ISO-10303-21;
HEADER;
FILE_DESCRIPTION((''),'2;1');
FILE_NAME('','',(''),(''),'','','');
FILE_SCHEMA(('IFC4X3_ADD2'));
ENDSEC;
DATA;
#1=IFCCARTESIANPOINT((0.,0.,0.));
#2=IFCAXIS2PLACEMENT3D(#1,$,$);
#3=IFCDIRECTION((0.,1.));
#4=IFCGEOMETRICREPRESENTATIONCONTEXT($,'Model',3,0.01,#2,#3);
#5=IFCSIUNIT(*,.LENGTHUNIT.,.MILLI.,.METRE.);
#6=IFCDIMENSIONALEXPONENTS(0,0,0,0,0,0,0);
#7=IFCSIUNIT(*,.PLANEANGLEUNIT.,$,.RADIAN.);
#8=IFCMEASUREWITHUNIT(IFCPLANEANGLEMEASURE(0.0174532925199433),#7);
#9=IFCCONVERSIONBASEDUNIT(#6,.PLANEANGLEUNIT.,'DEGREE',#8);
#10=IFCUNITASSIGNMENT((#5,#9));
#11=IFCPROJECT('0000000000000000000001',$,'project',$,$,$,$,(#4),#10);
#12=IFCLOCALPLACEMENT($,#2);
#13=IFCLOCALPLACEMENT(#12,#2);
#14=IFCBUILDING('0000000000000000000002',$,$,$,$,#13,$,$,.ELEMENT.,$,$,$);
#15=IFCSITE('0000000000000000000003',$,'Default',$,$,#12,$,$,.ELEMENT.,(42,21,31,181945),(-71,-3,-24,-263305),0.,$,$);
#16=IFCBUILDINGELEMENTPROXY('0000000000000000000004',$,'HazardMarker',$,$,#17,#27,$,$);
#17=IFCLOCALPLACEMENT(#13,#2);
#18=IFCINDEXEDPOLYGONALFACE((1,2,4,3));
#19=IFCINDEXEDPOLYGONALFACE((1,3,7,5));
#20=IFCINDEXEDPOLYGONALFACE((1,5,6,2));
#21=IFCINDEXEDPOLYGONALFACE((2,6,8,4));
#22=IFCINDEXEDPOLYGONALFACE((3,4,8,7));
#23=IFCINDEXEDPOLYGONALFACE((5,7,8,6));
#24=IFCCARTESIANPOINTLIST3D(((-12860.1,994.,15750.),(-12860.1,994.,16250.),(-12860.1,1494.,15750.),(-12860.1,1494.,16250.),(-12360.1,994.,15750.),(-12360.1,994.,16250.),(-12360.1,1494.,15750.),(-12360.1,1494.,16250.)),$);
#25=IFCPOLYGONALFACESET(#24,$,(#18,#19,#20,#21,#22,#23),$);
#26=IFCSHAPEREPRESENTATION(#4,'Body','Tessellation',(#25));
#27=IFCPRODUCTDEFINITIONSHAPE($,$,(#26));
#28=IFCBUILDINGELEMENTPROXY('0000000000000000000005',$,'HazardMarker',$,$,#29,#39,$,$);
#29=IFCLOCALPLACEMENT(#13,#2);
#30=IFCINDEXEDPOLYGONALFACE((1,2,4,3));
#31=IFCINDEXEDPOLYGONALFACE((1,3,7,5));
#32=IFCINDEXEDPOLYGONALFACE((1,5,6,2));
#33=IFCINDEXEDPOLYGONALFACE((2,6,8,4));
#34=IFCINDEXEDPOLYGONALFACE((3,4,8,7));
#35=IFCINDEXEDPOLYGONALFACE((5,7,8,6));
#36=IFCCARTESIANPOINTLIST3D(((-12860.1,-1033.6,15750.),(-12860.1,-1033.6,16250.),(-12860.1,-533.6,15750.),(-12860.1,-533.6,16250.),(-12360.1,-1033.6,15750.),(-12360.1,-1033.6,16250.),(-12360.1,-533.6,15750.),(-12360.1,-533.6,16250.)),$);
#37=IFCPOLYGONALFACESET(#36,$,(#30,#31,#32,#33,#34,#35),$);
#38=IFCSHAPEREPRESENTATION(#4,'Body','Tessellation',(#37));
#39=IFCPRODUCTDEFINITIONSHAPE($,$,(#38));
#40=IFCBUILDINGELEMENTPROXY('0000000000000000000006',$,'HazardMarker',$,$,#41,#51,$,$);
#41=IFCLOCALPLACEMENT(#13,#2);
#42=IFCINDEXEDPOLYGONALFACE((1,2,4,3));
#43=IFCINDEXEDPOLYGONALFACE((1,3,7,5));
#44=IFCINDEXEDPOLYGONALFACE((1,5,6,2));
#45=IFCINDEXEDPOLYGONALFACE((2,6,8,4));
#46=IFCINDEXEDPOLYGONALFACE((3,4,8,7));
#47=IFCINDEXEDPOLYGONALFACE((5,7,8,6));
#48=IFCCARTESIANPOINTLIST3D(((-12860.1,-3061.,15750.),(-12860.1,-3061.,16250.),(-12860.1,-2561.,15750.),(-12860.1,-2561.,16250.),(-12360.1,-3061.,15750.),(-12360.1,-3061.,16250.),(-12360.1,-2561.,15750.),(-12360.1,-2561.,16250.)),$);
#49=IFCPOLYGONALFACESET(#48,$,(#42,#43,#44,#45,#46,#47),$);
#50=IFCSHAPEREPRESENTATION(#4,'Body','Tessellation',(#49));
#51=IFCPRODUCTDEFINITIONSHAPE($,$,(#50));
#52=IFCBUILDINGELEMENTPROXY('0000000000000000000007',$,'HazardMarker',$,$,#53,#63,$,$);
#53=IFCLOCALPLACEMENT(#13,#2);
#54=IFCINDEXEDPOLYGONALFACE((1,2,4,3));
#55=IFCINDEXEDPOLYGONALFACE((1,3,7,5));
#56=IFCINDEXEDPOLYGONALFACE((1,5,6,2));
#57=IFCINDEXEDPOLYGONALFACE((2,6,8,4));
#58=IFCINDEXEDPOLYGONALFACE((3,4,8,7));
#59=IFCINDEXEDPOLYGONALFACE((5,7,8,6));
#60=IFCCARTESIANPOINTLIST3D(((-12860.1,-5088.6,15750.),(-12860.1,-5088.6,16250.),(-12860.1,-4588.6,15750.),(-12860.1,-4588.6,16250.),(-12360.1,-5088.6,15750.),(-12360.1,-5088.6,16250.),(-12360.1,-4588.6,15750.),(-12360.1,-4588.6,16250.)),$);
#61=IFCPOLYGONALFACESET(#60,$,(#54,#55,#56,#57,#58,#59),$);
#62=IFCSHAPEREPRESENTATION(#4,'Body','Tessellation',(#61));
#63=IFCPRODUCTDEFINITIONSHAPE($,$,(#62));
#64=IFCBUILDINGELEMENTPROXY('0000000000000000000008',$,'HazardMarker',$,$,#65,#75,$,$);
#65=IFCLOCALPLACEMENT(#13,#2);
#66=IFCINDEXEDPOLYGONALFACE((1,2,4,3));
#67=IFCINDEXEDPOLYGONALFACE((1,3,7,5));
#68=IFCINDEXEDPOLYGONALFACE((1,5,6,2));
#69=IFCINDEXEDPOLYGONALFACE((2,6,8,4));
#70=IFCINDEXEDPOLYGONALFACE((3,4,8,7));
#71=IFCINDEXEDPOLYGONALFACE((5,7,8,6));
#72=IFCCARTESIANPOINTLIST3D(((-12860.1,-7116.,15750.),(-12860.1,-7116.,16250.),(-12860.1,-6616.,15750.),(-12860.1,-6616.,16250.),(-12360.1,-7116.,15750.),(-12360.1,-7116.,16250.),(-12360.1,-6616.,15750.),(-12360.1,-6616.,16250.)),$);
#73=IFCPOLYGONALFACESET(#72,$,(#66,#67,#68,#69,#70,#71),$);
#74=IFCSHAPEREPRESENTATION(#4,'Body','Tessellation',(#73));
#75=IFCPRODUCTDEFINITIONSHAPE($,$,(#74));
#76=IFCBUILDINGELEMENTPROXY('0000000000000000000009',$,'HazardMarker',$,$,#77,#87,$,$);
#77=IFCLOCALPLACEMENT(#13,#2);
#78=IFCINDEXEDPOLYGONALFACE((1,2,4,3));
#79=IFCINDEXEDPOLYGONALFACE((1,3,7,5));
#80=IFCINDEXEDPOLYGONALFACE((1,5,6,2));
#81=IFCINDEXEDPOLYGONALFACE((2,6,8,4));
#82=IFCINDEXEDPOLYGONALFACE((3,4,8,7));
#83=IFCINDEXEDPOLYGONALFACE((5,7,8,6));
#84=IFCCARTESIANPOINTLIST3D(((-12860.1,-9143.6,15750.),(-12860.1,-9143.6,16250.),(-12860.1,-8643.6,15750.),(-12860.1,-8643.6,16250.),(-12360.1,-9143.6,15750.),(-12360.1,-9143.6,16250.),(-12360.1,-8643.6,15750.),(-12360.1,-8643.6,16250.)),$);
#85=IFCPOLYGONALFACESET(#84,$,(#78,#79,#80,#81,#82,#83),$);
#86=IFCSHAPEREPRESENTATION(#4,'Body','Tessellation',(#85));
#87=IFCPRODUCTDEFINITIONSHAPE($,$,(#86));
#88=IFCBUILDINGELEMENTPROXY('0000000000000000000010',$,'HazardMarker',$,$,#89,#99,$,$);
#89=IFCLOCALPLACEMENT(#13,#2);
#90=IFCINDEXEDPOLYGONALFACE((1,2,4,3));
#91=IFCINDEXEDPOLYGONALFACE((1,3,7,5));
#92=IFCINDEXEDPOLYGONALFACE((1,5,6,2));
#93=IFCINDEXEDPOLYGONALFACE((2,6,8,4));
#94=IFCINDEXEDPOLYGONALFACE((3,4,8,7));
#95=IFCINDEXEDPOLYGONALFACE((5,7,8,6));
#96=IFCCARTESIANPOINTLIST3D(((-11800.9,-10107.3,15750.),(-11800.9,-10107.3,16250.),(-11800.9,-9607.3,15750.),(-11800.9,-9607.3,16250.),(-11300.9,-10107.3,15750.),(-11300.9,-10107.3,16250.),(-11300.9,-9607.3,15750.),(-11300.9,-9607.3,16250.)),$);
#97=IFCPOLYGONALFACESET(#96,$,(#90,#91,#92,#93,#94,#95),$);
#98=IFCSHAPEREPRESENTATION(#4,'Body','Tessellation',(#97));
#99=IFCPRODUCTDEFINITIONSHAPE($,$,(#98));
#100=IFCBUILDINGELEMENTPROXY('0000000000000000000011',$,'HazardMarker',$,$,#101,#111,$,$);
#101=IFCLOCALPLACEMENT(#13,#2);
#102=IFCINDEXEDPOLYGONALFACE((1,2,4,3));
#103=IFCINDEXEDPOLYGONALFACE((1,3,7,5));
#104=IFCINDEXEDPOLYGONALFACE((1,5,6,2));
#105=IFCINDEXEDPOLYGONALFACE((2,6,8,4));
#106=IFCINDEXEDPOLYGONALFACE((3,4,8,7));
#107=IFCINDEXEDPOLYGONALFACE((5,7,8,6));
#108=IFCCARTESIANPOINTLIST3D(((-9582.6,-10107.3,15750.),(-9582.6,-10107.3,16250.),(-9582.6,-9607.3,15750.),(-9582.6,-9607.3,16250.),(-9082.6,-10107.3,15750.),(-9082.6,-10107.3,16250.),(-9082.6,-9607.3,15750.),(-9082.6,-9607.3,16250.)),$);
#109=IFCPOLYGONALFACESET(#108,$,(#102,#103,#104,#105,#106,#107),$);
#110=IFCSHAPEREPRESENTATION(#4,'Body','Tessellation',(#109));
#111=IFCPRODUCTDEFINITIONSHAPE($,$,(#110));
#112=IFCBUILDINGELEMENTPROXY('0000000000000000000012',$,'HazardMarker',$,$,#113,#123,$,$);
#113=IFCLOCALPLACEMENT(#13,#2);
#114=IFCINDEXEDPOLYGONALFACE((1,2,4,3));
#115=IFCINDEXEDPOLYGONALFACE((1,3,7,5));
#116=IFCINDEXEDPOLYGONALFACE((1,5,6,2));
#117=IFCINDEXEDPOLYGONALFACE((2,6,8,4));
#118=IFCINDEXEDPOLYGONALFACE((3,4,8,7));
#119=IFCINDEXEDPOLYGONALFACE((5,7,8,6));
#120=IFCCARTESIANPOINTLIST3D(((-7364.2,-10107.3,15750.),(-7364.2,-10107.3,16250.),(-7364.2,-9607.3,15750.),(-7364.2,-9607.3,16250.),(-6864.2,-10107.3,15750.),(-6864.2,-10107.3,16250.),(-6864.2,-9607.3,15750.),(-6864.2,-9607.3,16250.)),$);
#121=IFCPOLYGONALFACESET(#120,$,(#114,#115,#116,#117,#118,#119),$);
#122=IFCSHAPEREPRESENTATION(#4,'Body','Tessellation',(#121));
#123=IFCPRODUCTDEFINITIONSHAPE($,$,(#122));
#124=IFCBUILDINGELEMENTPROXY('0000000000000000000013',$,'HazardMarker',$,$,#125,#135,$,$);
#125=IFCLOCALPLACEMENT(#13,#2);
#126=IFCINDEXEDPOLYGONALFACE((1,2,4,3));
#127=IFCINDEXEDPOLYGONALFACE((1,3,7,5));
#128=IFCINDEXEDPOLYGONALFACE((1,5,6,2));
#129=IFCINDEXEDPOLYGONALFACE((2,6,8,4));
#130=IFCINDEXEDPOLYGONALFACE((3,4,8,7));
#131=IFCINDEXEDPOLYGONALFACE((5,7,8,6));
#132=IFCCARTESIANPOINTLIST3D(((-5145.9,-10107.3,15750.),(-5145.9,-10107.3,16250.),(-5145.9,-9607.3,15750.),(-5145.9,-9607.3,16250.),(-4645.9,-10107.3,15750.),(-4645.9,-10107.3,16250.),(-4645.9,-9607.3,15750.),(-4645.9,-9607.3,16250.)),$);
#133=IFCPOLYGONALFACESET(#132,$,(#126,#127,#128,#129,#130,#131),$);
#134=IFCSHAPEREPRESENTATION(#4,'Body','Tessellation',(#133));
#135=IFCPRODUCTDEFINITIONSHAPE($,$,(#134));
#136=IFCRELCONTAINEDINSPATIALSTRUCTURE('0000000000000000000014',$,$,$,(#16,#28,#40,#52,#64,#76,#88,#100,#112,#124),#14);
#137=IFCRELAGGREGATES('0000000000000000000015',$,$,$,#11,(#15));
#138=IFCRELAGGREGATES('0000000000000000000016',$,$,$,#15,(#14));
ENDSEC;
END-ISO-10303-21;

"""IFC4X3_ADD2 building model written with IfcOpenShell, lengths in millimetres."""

from ifc_helpers import new_model, entity, si_unit, converted_unit, direction, frame, origin, place, context, project, spatial, rectangle, extrude, element, save


model = new_model("IFC4X3_ADD2")

# Units and contexts
model_context = context("Model", 3, precision=0.01, world=origin(), true_north=direction((0.0, 1.0)))
ifc_project = project(units=[si_unit("LENGTHUNIT", "METRE", prefix="MILLI"), converted_unit("PLANEANGLEUNIT", "DEGREE", entity("IfcPlaneAngleMeasure", 0.0174532925199433), si_unit("PLANEANGLEUNIT", "RADIAN"), dimensions=[0, 0, 0, 0, 0, 0, 0])], contexts=[model_context])

# Site, building
site_placement = place(None, origin())
site = spatial("IfcSite", under=ifc_project, at=site_placement, Name="Default", CompositionType="ELEMENT", RefLatitude=(42, 21, 31, 181945), RefLongitude=(-71, -3, -24, -263305), RefElevation=0.0)
building_placement = place(site_placement, origin())
building = spatial("IfcBuilding", under=site, at=building_placement, CompositionType="ELEMENT")

# Building element proxies
for number, where, name in (
    (1, (-12610.1, 1244.0, 16000.0), "HazardMarker"),
    (2, (-12610.1, -783.5, 16000.0), "HazardMarker"),
    (3, (-12610.1, -2811.1, 16000.0), "HazardMarker"),
    (4, (-12610.1, -4838.6, 16000.0), "HazardMarker"),
    (5, (-12610.1, -6866.1, 16000.0), "HazardMarker"),
    (6, (-12610.1, -8893.5, 16000.0), "HazardMarker"),
    (7, (-11550.9, -9857.3, 16000.0), "HazardMarker"),
    (8, (-9332.6, -9857.3, 16000.0), "HazardMarker"),
    (9, (-7114.2, -9857.3, 16000.0), "HazardMarker"),
    (10, (-4895.9, -9857.3, 16000.0), "HazardMarker"),
):
    element("IfcBuildingElementProxy", number, at=place(None, frame(where)), inside=building, Name=name, context=model_context, shape_type="SweptSolid", body=[
        extrude(rectangle(XDim=500.0, YDim=500.0), frame((0.0, 0.0, -250.0)), (0.0, 0.0, 1.0), 500.0),
    ])

save(model, "model.ifc")
